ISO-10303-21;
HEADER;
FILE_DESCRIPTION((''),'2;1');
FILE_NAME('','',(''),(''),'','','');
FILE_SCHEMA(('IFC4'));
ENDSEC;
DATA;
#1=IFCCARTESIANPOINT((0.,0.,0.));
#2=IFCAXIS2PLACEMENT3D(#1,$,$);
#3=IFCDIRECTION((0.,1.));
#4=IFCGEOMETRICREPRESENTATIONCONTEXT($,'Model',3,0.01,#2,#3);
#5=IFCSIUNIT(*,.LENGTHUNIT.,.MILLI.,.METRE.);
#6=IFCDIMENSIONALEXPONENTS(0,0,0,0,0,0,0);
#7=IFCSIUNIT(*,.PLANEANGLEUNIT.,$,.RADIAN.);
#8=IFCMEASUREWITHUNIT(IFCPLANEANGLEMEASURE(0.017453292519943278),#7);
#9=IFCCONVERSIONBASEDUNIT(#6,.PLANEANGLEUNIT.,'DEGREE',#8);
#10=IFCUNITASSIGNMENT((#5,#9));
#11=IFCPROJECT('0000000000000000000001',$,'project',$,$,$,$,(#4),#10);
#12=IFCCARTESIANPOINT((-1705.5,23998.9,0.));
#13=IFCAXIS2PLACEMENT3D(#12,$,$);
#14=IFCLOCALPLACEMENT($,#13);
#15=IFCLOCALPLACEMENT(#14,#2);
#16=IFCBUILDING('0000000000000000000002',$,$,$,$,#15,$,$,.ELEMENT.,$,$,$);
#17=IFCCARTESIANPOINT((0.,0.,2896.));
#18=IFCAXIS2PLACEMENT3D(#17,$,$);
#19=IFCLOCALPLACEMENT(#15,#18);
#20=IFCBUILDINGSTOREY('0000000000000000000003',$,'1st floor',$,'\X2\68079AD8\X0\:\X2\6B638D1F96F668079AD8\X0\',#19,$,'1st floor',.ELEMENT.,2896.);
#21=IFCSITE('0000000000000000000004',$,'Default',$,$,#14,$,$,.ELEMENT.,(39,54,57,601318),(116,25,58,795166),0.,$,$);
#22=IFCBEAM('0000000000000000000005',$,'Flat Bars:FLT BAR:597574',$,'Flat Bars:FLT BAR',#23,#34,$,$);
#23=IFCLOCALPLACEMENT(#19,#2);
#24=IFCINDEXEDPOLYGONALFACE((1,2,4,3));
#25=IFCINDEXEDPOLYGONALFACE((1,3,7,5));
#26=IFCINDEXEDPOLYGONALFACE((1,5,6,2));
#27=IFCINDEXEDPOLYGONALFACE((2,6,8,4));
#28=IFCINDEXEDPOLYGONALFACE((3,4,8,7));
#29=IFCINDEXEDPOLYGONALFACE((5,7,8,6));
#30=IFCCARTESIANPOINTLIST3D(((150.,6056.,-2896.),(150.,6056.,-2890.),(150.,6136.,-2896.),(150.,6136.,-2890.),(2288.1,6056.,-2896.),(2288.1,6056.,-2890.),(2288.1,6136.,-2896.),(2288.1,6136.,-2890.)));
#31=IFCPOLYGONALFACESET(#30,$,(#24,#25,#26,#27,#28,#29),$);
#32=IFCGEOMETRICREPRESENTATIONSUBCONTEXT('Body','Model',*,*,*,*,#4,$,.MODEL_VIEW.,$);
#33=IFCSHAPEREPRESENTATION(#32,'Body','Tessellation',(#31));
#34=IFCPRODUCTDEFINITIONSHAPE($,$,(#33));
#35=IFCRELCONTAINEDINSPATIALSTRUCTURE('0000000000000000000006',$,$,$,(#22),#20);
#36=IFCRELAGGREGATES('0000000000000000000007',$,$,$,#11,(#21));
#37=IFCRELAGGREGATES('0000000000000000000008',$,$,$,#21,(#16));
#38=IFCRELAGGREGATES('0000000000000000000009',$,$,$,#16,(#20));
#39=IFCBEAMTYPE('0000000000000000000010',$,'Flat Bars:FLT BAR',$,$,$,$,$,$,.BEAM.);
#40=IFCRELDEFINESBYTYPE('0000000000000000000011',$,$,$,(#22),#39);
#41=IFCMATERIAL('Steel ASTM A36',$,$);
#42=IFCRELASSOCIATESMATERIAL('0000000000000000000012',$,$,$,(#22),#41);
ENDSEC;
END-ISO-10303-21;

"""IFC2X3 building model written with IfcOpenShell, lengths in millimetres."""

from ifc_helpers import new_model, entity, si_unit, converted_unit, direction, frame, origin, origin_2d_with_axis, place, context, subcontext, project, spatial, rectangle, extrude, material, type_object, element, save


model = new_model("IFC2X3")

# Units and contexts
model_context = context("Model", 3, precision=0.01, world=origin(), true_north=direction((0.0, 1.0)))
body_context = subcontext(model_context, "Body", "Model", "MODEL_VIEW")
ifc_project = project(units=[si_unit("LENGTHUNIT", "METRE", prefix="MILLI"), converted_unit("PLANEANGLEUNIT", "DEGREE", entity("IfcPlaneAngleMeasure", 0.017453292519943278), si_unit("PLANEANGLEUNIT", "RADIAN"), dimensions=[0, 0, 0, 0, 0, 0, 0])], contexts=[model_context])

# Site, building, storey
site_placement = place(None, frame((-1705.5, 23998.9, 0.0)))
site = spatial("IfcSite", under=ifc_project, at=site_placement, Name="Default", CompositionType="ELEMENT", RefLatitude=(39, 54, 57, 601318), RefLongitude=(116, 25, 58, 795166), RefElevation=0.0)
building_placement = place(site_placement, origin())
building = spatial("IfcBuilding", under=site, at=building_placement, CompositionType="ELEMENT")
storey_placement = place(building_placement, frame((0.0, 0.0, 2896.0)))
storey = spatial("IfcBuildingStorey", under=building, at=storey_placement, Name="1st floor", ObjectType="标高:正负零标高", LongName="1st floor", CompositionType="ELEMENT", Elevation=2896.0)

# Beam
ifc_material_1 = material(Name="Steel ASTM A36")
beam_type_1 = type_object("IfcBeamType", Name="Flat Bars:FLT BAR", PredefinedType="BEAM")
for number, where, name in (
    (1, (150.0, 6096.0, -2890.0), "Flat Bars:FLT BAR:597574"),
):
    element("IfcBeam", number, at=place(storey_placement, frame(where)), inside=storey, type_object=beam_type_1, material=ifc_material_1, Name=name, ObjectType="Flat Bars:FLT BAR", context=body_context, shape_type="SweptSolid", body=[
        extrude(rectangle(XDim=6.0, YDim=80.0, at=origin_2d_with_axis()), frame((0.0, 0.0, -3.0), z_axis=(1.0, 0.0, 0.0), x_axis=(0.0, 0.0, -1.0)), (0.0, 0.0, 1.0), 2138.1),
    ])

save(model, "model.ifc")
